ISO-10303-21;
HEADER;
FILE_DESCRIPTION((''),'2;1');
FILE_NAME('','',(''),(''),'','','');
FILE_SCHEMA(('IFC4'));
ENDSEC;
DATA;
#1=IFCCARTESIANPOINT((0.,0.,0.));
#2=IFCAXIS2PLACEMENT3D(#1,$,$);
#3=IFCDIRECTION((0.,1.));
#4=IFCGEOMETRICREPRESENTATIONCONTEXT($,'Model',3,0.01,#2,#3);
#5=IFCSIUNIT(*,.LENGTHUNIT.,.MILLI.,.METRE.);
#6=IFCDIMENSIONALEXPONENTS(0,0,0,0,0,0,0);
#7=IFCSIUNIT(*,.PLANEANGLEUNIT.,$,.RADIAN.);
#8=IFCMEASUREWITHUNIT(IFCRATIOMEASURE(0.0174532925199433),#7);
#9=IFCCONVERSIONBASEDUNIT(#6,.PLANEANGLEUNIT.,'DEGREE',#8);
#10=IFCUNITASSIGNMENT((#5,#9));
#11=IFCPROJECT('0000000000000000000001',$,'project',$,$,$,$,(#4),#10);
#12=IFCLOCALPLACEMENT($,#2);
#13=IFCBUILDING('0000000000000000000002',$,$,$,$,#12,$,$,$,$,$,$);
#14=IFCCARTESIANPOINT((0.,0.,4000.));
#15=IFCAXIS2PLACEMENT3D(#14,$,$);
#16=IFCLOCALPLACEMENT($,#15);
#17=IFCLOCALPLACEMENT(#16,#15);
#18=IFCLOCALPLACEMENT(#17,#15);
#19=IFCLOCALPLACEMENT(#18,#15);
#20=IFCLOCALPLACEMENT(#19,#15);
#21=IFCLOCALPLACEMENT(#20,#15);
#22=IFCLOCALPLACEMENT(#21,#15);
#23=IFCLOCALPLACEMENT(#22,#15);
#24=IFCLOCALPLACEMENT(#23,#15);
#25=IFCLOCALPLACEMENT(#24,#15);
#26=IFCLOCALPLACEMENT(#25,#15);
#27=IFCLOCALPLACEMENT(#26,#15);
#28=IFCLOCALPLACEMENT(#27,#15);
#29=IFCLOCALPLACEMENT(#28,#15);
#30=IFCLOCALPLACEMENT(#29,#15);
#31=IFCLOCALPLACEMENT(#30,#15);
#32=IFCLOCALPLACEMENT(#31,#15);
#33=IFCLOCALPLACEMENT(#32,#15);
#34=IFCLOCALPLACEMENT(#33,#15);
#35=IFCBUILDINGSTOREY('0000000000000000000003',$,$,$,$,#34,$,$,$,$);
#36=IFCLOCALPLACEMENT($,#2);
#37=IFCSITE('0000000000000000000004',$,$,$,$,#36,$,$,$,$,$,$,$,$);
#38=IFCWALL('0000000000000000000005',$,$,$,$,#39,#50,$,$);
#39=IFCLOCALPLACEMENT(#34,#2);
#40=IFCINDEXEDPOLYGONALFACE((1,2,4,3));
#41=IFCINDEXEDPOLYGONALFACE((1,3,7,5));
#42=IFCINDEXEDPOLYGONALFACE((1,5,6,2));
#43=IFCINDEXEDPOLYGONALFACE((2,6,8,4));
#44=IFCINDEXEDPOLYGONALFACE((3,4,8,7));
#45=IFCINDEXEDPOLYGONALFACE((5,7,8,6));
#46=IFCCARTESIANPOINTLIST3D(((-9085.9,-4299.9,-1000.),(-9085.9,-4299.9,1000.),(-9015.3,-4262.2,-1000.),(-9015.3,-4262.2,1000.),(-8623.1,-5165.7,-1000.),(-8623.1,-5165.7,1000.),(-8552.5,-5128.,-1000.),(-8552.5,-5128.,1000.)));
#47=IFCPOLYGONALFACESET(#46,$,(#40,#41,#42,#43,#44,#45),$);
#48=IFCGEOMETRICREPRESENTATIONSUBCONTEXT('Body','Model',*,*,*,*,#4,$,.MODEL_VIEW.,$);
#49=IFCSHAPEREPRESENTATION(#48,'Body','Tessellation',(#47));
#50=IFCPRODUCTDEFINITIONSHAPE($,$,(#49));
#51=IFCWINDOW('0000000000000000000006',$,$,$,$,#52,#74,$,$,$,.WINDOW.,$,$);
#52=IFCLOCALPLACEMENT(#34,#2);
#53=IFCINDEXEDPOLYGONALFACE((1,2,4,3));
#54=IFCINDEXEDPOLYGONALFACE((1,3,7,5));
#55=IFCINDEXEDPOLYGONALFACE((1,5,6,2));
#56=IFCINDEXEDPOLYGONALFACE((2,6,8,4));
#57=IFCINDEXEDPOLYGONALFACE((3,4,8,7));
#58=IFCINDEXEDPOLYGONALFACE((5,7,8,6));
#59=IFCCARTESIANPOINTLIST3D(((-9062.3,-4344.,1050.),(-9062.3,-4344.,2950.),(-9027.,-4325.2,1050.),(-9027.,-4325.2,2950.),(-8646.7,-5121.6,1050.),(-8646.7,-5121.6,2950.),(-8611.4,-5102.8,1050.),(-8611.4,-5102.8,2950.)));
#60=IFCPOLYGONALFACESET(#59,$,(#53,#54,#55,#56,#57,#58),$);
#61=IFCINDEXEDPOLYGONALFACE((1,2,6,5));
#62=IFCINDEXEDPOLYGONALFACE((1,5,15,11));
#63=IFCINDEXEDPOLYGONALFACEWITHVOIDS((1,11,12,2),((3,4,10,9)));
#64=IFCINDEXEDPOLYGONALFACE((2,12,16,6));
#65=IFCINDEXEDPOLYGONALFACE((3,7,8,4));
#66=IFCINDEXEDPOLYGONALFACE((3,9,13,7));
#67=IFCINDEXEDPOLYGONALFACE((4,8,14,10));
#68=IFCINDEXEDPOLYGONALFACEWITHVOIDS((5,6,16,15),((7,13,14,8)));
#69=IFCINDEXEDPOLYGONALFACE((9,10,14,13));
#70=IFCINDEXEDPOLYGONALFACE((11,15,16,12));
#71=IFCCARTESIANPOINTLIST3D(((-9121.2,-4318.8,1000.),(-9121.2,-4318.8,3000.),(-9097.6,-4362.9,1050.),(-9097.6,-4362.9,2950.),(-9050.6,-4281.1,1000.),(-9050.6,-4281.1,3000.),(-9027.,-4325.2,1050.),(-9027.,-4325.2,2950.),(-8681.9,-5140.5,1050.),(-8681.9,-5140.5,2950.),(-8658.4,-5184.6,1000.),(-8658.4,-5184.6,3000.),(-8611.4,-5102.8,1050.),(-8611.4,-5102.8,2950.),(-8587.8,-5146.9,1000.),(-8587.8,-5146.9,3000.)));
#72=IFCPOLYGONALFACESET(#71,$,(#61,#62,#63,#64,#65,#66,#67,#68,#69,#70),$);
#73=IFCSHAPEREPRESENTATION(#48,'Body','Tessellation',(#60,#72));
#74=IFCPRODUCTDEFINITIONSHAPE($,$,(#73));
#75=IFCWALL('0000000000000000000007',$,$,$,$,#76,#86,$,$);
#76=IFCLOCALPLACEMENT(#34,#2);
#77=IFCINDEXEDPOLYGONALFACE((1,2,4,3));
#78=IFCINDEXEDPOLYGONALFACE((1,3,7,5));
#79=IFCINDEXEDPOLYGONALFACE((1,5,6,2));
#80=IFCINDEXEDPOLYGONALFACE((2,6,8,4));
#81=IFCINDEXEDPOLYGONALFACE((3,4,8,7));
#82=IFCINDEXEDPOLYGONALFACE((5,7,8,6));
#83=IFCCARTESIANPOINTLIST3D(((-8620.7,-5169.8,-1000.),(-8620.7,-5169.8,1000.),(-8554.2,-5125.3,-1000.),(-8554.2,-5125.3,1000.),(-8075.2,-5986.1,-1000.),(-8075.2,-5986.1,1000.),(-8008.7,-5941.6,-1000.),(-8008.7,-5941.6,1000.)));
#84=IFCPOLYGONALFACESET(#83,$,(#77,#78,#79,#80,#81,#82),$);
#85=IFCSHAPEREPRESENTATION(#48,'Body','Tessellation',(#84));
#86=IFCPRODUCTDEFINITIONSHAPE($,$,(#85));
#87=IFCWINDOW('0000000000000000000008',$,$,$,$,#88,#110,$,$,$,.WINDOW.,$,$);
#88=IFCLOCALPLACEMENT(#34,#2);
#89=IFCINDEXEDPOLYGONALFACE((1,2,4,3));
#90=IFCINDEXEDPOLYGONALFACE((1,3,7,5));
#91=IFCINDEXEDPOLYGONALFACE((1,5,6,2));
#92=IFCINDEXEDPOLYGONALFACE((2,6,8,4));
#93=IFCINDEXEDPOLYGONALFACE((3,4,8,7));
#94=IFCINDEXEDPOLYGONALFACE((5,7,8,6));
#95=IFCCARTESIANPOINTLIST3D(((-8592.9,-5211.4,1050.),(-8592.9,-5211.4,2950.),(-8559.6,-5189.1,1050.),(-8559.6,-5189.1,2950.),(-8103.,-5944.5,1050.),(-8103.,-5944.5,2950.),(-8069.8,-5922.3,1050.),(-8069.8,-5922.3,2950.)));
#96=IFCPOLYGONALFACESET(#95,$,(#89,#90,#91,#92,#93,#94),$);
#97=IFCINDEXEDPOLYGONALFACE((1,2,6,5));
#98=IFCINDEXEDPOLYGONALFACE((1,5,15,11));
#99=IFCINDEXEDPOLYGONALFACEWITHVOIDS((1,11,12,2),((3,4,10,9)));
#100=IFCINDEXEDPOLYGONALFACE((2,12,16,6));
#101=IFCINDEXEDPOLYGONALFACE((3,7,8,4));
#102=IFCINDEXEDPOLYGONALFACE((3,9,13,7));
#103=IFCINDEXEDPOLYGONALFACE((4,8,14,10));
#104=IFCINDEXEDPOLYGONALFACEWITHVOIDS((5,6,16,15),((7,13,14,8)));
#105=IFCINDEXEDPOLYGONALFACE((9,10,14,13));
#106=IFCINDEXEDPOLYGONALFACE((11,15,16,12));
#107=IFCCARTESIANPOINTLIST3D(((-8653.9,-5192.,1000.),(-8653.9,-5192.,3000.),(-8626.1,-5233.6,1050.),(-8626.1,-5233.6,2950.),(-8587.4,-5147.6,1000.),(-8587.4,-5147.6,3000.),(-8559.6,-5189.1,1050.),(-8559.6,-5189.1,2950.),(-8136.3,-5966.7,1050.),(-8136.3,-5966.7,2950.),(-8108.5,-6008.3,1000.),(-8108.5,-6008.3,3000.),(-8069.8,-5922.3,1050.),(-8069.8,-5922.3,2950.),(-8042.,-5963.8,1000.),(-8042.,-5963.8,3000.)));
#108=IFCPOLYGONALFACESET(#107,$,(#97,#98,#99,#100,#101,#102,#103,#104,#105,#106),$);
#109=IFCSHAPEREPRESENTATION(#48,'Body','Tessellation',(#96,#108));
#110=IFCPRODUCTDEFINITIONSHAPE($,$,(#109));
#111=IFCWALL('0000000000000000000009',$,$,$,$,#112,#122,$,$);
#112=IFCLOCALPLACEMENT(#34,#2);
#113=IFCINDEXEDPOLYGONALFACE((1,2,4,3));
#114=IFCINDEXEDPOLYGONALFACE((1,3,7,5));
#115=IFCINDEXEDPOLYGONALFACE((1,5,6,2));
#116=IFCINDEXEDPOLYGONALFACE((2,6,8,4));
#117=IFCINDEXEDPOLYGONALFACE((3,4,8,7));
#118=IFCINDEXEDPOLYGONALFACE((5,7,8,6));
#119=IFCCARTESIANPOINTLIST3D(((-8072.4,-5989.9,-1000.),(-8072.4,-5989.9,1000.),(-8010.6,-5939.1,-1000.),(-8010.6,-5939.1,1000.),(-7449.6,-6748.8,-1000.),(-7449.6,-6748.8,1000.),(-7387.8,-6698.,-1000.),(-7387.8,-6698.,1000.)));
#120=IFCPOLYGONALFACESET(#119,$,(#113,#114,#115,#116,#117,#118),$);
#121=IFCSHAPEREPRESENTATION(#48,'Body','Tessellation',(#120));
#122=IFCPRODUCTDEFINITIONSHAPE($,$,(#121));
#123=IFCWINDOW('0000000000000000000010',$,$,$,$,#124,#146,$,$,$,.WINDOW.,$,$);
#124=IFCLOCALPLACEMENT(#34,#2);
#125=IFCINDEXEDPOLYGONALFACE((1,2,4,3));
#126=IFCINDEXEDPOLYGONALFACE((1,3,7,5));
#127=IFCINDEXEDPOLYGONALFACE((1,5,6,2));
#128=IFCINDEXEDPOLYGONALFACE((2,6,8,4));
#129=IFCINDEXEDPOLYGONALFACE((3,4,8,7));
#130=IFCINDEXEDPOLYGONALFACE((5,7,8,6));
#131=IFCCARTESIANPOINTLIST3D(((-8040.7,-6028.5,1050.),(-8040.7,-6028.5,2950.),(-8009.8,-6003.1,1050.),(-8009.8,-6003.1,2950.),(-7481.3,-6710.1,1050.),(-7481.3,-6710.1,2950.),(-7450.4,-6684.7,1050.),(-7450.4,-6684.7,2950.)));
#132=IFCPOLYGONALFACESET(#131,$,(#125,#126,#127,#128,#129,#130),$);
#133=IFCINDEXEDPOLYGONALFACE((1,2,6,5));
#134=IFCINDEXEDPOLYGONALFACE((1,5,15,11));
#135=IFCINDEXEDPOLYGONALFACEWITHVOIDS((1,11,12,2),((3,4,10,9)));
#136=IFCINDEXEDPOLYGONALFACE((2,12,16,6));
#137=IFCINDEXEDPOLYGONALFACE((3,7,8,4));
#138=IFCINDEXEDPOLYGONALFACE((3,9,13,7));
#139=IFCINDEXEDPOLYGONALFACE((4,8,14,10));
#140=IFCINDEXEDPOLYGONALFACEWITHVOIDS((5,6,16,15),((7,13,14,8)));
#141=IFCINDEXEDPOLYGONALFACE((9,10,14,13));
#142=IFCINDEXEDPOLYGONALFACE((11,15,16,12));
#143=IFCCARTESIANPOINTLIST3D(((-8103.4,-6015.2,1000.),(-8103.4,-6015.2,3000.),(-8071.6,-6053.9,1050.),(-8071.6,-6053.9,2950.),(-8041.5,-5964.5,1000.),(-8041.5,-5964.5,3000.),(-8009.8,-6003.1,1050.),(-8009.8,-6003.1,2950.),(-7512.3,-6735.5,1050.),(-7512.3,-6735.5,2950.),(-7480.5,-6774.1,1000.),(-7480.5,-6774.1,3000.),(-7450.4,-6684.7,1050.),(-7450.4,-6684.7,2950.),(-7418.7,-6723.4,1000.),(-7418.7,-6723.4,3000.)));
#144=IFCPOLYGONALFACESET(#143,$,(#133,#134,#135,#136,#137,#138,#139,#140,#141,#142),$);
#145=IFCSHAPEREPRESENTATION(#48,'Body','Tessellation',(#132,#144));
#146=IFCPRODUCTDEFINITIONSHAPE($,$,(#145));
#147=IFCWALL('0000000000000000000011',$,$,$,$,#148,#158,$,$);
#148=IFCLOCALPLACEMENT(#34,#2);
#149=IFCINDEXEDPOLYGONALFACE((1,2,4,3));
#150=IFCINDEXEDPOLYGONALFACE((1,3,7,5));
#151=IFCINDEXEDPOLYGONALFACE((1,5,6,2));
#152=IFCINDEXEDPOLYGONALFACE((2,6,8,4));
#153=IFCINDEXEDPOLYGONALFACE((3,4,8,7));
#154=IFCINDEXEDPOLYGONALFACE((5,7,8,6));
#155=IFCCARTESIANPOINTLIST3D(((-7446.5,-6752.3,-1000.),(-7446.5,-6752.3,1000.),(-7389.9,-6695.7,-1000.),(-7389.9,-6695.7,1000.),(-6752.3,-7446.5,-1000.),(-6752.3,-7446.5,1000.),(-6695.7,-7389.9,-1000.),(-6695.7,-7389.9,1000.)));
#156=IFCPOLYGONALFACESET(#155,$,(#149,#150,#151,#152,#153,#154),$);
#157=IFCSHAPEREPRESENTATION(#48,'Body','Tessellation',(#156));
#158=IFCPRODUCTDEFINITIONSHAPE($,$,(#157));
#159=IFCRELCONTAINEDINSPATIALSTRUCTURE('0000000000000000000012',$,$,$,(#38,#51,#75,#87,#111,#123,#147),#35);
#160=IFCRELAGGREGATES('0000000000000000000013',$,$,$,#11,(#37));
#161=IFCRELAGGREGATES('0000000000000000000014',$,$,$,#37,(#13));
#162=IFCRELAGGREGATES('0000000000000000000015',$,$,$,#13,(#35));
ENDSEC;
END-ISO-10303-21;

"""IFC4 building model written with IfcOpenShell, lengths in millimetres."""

from ifc_helpers import new_model, entity, si_unit, converted_unit, direction, frame, origin, origin_2d, place, context, subcontext, project, spatial, rectangle, extrude, element, save


model = new_model("IFC4")

# Units and contexts
model_context = context("Model", 3, precision=0.01, world=origin(), true_north=direction((0.0, 1.0)))
body_context = subcontext(model_context, "Body", "Model", "MODEL_VIEW")
ifc_project = project(units=[si_unit("LENGTHUNIT", "METRE", prefix="MILLI"), converted_unit("PLANEANGLEUNIT", "DEGREE", entity("IfcRatioMeasure", 0.0174532925199433), si_unit("PLANEANGLEUNIT", "RADIAN"), dimensions=[0, 0, 0, 0, 0, 0, 0])], contexts=[model_context])

# Site, building, storey
site_placement = place(None, origin())
site = spatial("IfcSite", under=ifc_project, at=site_placement)
building_placement = place(None, origin())
building = spatial("IfcBuilding", under=site, at=building_placement)
placement_1 = place(None, frame((0.0, 0.0, 4000.0)))
placement_2 = place(placement_1, frame((0.0, 0.0, 4000.0)))
placement_3 = place(placement_2, frame((0.0, 0.0, 4000.0)))
placement_4 = place(placement_3, frame((0.0, 0.0, 4000.0)))
placement_5 = place(placement_4, frame((0.0, 0.0, 4000.0)))
placement_6 = place(placement_5, frame((0.0, 0.0, 4000.0)))
placement_7 = place(placement_6, frame((0.0, 0.0, 4000.0)))
placement_8 = place(placement_7, frame((0.0, 0.0, 4000.0)))
placement_9 = place(placement_8, frame((0.0, 0.0, 4000.0)))
placement_10 = place(placement_9, frame((0.0, 0.0, 4000.0)))
placement_11 = place(placement_10, frame((0.0, 0.0, 4000.0)))
placement_12 = place(placement_11, frame((0.0, 0.0, 4000.0)))
placement_13 = place(placement_12, frame((0.0, 0.0, 4000.0)))
placement_14 = place(placement_13, frame((0.0, 0.0, 4000.0)))
placement_15 = place(placement_14, frame((0.0, 0.0, 4000.0)))
placement_16 = place(placement_15, frame((0.0, 0.0, 4000.0)))
placement_17 = place(placement_16, frame((0.0, 0.0, 4000.0)))
placement_18 = place(placement_17, frame((0.0, 0.0, 4000.0)))
storey_placement = place(placement_18, frame((0.0, 0.0, 4000.0)))
storey = spatial("IfcBuildingStorey", under=building, at=storey_placement)

# Shared definitions
cartesian_point_1 = entity("IfcCartesianPoint", [-440.9, -950.0])
shared_polyline = entity("IfcPolyline", [cartesian_point_1, entity("IfcCartesianPoint", [-440.9, 950.0]), entity("IfcCartesianPoint", [-440.9, 950.0]), entity("IfcCartesianPoint", [440.9, 950.0]), entity("IfcCartesianPoint", [440.9, 950.0]), entity("IfcCartesianPoint", [440.9, -950.0]), entity("IfcCartesianPoint", [440.9, -950.0]), entity("IfcCartesianPoint", [-440.9, -950.0]), cartesian_point_1])

# Wall
wall_1_placement = place(storey_placement, frame((-8819.2, -4714.0, -1000.0), z_axis=(0.0, 0.0, 1.0), x_axis=(4713.9678, -8819.212413, 0.0)))
element("IfcWall", 1, at=wall_1_placement, inside=storey, context=body_context, shape_type="SweptSolid", body=[
    extrude(rectangle(XDim=981.7, YDim=80.0, at=origin_2d()), origin(), (0.0, 0.0, 1.0), 2000.0),
])

# Window
window_1_placement = place(storey_placement, frame((-8819.2, -4714.0, 2000.0), z_axis=(0.0, 0.0, 1.0), x_axis=(4713.9678, -8819.212413, 0.0)))
cartesian_point_2 = entity("IfcCartesianPoint", [-490.9, -1000.0])
element("IfcWindow", 2, at=window_1_placement, inside=storey, PredefinedType="WINDOW", context=body_context, shape_type="SweptSolid", body=[
    entity("IfcExtrudedAreaSolid", entity("IfcArbitraryClosedProfileDef", "AREA", None, shared_polyline), entity("IfcAxis2Placement3D", entity("IfcCartesianPoint", [0.0, 0.0, 0.0]), entity("IfcDirection", [0.0, -1.0, 0.0]), entity("IfcDirection", [1.0, 0.0, 0.0])), entity("IfcDirection", [0.0, 0.0, 1.0]), 40.0),
    entity("IfcExtrudedAreaSolid", entity("IfcArbitraryProfileDefWithVoids", "AREA", None, entity("IfcPolyline", [cartesian_point_2, entity("IfcCartesianPoint", [-490.9, 1000.0]), entity("IfcCartesianPoint", [-490.9, 1000.0]), entity("IfcCartesianPoint", [490.9, 1000.0]), entity("IfcCartesianPoint", [490.9, 1000.0]), entity("IfcCartesianPoint", [490.9, -1000.0]), entity("IfcCartesianPoint", [490.9, -1000.0]), entity("IfcCartesianPoint", [-490.9, -1000.0]), cartesian_point_2]), [shared_polyline]), entity("IfcAxis2Placement3D", entity("IfcCartesianPoint", [0.0, 0.0, 0.0]), entity("IfcDirection", [0.0, -1.0, 0.0]), entity("IfcDirection", [1.0, 0.0, 0.0])), entity("IfcDirection", [0.0, 0.0, 1.0]), 80.0),
])

# Wall
wall_2_placement = place(storey_placement, frame((-8314.7, -5555.7, -1000.0), z_axis=(0.0, 0.0, 1.0), x_axis=(5555.703069, -8314.695629, 0.0)))
element("IfcWall", 3, at=wall_2_placement, inside=storey, context=body_context, shape_type="SweptSolid", body=[
    extrude(rectangle(XDim=981.7, YDim=80.0, at=origin_2d()), origin(), (0.0, 0.0, 1.0), 2000.0),
])

# Window
window_2_placement = place(storey_placement, frame((-8314.7, -5555.7, 2000.0), z_axis=(0.0, 0.0, 1.0), x_axis=(5555.703069, -8314.695629, 0.0)))
cartesian_point_3 = entity("IfcCartesianPoint", [-490.9, -1000.0])
element("IfcWindow", 4, at=window_2_placement, inside=storey, PredefinedType="WINDOW", context=body_context, shape_type="SweptSolid", body=[
    entity("IfcExtrudedAreaSolid", entity("IfcArbitraryClosedProfileDef", "AREA", None, shared_polyline), entity("IfcAxis2Placement3D", entity("IfcCartesianPoint", [0.0, 0.0, 0.0]), entity("IfcDirection", [0.0, -1.0, 0.0]), entity("IfcDirection", [1.0, 0.0, 0.0])), entity("IfcDirection", [0.0, 0.0, 1.0]), 40.0),
    entity("IfcExtrudedAreaSolid", entity("IfcArbitraryProfileDefWithVoids", "AREA", None, entity("IfcPolyline", [cartesian_point_3, entity("IfcCartesianPoint", [-490.9, 1000.0]), entity("IfcCartesianPoint", [-490.9, 1000.0]), entity("IfcCartesianPoint", [490.9, 1000.0]), entity("IfcCartesianPoint", [490.9, 1000.0]), entity("IfcCartesianPoint", [490.9, -1000.0]), entity("IfcCartesianPoint", [490.9, -1000.0]), entity("IfcCartesianPoint", [-490.9, -1000.0]), cartesian_point_3]), [shared_polyline]), entity("IfcAxis2Placement3D", entity("IfcCartesianPoint", [0.0, 0.0, 0.0]), entity("IfcDirection", [0.0, -1.0, 0.0]), entity("IfcDirection", [1.0, 0.0, 0.0])), entity("IfcDirection", [0.0, 0.0, 1.0]), 80.0),
])

# Wall
wall_3_placement = place(storey_placement, frame((-7730.1, -6343.9, -1000.0), z_axis=(0.0, 0.0, 1.0), x_axis=(6343.931995, -7730.105228, 0.0)))
element("IfcWall", 5, at=wall_3_placement, inside=storey, context=body_context, shape_type="SweptSolid", body=[
    extrude(rectangle(XDim=981.7, YDim=80.0, at=origin_2d()), origin(), (0.0, 0.0, 1.0), 2000.0),
])

# Window
window_3_placement = place(storey_placement, frame((-7730.1, -6343.9, 2000.0), z_axis=(0.0, 0.0, 1.0), x_axis=(6343.931995, -7730.105228, 0.0)))
cartesian_point_4 = entity("IfcCartesianPoint", [-490.9, -1000.0])
element("IfcWindow", 6, at=window_3_placement, inside=storey, PredefinedType="WINDOW", context=body_context, shape_type="SweptSolid", body=[
    entity("IfcExtrudedAreaSolid", entity("IfcArbitraryClosedProfileDef", "AREA", None, shared_polyline), entity("IfcAxis2Placement3D", entity("IfcCartesianPoint", [0.0, 0.0, 0.0]), entity("IfcDirection", [0.0, -1.0, 0.0]), entity("IfcDirection", [1.0, 0.0, 0.0])), entity("IfcDirection", [0.0, 0.0, 1.0]), 40.0),
    entity("IfcExtrudedAreaSolid", entity("IfcArbitraryProfileDefWithVoids", "AREA", None, entity("IfcPolyline", [cartesian_point_4, entity("IfcCartesianPoint", [-490.9, 1000.0]), entity("IfcCartesianPoint", [-490.9, 1000.0]), entity("IfcCartesianPoint", [490.9, 1000.0]), entity("IfcCartesianPoint", [490.9, 1000.0]), entity("IfcCartesianPoint", [490.9, -1000.0]), entity("IfcCartesianPoint", [490.9, -1000.0]), entity("IfcCartesianPoint", [-490.9, -1000.0]), cartesian_point_4]), [shared_polyline]), entity("IfcAxis2Placement3D", entity("IfcCartesianPoint", [0.0, 0.0, 0.0]), entity("IfcDirection", [0.0, -1.0, 0.0]), entity("IfcDirection", [1.0, 0.0, 0.0])), entity("IfcDirection", [0.0, 0.0, 1.0]), 80.0),
])

# Wall
wall_4_placement = place(storey_placement, frame((-7071.1, -7071.1, -1000.0), z_axis=(0.0, 0.0, 1.0), x_axis=(7071.06732, -7071.068304, 0.0)))
element("IfcWall", 7, at=wall_4_placement, inside=storey, context=body_context, shape_type="SweptSolid", body=[
    extrude(rectangle(XDim=981.7, YDim=80.0, at=origin_2d()), origin(), (0.0, 0.0, 1.0), 2000.0),
])

save(model, "model.ifc")
